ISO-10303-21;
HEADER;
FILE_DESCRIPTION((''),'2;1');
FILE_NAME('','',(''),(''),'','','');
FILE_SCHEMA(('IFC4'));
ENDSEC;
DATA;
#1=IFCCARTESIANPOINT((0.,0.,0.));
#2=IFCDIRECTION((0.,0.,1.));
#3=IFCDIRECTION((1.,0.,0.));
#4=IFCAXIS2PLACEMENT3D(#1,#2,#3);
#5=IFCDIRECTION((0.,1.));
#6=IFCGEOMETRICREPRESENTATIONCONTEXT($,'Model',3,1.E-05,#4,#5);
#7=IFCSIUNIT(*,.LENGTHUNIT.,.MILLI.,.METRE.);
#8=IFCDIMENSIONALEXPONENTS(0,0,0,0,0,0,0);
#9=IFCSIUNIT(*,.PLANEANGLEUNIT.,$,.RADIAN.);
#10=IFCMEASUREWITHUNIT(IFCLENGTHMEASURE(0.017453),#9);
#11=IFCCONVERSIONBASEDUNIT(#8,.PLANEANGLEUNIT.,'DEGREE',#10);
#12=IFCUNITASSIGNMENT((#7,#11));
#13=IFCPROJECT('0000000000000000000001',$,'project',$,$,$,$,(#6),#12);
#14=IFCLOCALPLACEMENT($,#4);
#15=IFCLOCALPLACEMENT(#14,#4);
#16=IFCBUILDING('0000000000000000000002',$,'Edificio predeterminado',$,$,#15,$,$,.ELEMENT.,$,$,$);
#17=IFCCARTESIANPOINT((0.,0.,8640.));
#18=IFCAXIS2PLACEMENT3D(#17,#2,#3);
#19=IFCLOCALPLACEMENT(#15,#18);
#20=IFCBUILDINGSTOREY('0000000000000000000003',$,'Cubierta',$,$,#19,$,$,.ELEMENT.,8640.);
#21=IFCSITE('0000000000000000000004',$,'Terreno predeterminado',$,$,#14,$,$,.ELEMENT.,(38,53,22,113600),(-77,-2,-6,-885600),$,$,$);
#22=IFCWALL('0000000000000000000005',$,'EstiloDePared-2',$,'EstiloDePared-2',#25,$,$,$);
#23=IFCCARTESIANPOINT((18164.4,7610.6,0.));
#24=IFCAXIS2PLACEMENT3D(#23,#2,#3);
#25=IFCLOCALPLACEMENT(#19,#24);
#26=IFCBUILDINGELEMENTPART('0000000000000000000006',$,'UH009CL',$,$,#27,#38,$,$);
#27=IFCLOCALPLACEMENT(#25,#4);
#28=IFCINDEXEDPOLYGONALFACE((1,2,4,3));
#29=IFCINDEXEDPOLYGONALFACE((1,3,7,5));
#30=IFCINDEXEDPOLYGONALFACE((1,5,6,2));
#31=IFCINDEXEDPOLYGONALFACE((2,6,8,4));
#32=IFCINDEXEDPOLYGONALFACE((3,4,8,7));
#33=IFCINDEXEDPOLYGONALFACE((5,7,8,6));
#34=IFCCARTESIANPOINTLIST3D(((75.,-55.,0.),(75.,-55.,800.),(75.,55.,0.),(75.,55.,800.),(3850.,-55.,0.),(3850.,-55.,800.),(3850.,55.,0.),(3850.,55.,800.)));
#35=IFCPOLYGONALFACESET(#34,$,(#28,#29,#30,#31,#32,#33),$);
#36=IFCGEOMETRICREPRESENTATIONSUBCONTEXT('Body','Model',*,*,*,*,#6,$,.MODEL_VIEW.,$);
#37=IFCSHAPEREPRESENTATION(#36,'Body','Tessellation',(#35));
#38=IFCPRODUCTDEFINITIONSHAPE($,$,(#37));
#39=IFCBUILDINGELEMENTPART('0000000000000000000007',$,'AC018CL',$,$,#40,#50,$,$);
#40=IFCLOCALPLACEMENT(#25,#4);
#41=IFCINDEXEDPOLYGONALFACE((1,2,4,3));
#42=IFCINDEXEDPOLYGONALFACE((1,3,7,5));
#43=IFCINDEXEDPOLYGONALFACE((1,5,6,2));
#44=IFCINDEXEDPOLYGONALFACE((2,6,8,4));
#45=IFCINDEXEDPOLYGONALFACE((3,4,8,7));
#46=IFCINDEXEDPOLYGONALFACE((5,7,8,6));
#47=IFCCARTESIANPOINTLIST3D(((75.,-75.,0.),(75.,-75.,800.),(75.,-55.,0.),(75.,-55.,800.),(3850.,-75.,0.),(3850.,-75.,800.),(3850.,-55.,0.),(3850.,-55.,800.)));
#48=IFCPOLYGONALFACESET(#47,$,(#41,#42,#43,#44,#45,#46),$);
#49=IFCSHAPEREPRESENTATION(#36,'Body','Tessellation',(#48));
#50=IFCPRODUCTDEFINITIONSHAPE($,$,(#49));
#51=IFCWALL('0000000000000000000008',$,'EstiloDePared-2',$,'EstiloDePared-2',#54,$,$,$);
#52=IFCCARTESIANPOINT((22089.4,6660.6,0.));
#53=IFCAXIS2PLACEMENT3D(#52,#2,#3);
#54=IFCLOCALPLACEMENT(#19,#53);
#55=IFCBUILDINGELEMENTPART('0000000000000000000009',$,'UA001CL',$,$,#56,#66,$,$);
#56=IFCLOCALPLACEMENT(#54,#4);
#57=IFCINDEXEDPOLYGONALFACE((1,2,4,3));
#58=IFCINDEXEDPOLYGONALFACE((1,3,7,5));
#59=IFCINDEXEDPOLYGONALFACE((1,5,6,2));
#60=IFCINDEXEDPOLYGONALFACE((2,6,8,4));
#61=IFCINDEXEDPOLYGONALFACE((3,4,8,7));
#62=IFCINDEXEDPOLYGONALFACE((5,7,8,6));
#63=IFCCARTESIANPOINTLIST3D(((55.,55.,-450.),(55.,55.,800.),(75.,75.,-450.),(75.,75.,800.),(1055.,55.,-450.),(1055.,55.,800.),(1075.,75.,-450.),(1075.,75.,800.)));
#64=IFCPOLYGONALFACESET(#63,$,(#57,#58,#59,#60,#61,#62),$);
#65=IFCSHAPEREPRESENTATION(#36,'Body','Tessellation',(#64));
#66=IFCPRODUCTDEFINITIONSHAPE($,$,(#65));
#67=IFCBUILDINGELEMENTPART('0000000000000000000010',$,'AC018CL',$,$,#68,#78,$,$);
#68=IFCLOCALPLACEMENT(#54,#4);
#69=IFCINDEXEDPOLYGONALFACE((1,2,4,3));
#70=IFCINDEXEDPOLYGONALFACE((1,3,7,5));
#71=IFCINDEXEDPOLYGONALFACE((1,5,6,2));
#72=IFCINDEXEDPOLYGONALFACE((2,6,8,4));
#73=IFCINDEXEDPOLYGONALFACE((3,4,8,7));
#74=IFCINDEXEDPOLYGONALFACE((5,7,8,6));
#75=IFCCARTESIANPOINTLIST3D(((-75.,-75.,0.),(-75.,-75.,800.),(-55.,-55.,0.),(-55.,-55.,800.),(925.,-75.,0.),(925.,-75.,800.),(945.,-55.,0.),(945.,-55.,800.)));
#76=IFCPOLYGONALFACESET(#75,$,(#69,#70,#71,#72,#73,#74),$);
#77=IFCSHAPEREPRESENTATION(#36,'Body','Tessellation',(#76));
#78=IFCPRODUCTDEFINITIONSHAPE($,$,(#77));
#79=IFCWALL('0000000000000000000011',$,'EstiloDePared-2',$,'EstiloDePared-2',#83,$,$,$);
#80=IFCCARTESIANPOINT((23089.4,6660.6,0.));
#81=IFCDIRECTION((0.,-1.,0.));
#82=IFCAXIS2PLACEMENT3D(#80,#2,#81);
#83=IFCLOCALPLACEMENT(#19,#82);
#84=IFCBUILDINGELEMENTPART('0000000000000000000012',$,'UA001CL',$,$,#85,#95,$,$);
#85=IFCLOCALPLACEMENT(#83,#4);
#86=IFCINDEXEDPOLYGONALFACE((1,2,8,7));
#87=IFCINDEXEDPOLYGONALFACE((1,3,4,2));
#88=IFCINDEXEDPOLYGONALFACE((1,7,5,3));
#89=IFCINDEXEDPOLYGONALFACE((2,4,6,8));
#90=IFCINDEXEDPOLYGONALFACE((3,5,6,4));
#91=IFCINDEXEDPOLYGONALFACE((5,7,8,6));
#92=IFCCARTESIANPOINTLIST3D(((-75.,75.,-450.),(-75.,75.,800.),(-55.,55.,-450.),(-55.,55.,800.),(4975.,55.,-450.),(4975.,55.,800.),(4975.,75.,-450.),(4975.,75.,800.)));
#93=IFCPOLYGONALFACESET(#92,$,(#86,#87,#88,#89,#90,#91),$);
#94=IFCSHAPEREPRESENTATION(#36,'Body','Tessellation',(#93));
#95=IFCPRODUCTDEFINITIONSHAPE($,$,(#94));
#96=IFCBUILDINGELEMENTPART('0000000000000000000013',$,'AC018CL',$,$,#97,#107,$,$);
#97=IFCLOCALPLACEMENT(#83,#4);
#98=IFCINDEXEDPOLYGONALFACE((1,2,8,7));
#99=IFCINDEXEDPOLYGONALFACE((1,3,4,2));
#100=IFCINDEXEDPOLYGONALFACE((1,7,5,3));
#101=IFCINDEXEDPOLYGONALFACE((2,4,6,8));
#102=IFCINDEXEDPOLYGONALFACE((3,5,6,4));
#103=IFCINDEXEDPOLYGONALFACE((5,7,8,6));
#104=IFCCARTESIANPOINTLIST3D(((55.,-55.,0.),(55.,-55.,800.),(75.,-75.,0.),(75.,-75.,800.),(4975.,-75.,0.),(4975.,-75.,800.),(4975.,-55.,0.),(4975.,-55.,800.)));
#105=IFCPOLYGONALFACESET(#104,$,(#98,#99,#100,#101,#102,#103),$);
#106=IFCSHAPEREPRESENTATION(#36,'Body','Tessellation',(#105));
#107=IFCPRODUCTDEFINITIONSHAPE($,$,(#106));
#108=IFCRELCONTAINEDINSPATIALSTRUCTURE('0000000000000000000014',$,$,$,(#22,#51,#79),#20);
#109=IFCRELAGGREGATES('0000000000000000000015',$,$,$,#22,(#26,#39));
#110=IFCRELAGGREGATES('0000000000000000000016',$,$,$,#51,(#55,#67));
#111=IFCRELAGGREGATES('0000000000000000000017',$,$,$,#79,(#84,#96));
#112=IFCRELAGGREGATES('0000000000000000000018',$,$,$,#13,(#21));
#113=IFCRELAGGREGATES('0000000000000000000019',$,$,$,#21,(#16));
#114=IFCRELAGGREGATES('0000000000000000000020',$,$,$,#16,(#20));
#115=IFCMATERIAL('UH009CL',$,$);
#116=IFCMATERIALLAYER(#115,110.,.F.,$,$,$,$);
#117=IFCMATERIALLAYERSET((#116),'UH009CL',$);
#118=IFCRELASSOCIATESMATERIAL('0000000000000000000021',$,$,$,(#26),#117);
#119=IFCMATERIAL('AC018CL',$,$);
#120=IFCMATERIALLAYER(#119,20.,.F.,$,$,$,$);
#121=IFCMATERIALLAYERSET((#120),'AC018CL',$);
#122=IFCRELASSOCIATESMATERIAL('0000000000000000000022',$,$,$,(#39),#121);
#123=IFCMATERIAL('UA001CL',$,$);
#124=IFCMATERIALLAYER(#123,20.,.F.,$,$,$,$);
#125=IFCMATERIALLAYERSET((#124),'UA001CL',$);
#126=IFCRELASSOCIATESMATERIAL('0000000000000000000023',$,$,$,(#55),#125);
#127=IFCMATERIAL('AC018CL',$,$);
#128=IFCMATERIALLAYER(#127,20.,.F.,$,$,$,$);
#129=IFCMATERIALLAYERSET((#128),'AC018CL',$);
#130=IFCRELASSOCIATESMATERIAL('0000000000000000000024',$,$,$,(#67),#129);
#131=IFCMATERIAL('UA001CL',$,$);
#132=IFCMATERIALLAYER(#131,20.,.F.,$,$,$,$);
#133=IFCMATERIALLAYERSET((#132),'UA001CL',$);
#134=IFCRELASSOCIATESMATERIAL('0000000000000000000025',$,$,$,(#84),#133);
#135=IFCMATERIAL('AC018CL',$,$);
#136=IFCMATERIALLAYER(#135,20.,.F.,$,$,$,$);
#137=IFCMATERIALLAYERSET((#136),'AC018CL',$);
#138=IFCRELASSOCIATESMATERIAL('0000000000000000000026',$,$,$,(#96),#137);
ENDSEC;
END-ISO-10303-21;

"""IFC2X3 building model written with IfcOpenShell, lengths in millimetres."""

from ifc_helpers import new_model, entity, si_unit, converted_unit, direction, frame, origin_with_axes, place, context, subcontext, project, spatial, polyline, outline, extrude, material, layer, layer_set, layer_usage, element, aggregate, save


model = new_model("IFC2X3")

# Units and contexts
model_context = context("Model", 3, precision=1e-05, world=origin_with_axes(), true_north=direction((0.0, 1.0)))
body_context = subcontext(model_context, "Body", "Model", "MODEL_VIEW")
ifc_project = project(units=[si_unit("LENGTHUNIT", "METRE", prefix="MILLI"), converted_unit("PLANEANGLEUNIT", "DEGREE", entity("IfcLengthMeasure", 0.017453), si_unit("PLANEANGLEUNIT", "RADIAN"), dimensions=[0, 0, 0, 0, 0, 0, 0])], contexts=[model_context])

# Site, building, storey
site_placement = place(None, origin_with_axes())
site = spatial("IfcSite", under=ifc_project, at=site_placement, Name="Terreno predeterminado", CompositionType="ELEMENT", RefLatitude=(38, 53, 22, 113600), RefLongitude=(-77, -2, -6, -885600))
building_placement = place(site_placement, origin_with_axes())
building = spatial("IfcBuilding", under=site, at=building_placement, Name="Edificio predeterminado", CompositionType="ELEMENT")
storey_placement = place(building_placement, frame((0.0, 0.0, 8640.0), z_axis=(0.0, 0.0, 1.0), x_axis=(1.0, 0.0, 0.0)))
storey = spatial("IfcBuildingStorey", under=building, at=storey_placement, Name="Cubierta", CompositionType="ELEMENT", Elevation=8640.0)

# Walls, building element parts
wall_1_placement = place(storey_placement, frame((18164.4, 7610.6, 0.0), z_axis=(0.0, 0.0, 1.0), x_axis=(1.0, 0.0, 0.0)))
wall_1 = element("IfcWall", 1, at=wall_1_placement, inside=storey, Name="EstiloDePared-2", ObjectType="EstiloDePared-2")
ifc_material_1 = material(Name="UH009CL")
ifc_layer_1 = layer(ifc_material_1, 110.0, ventilated=False)
ifc_layer_set_1 = layer_set([ifc_layer_1], Name="UH009CL")
ifc_layer_usage_1 = layer_usage(ifc_layer_set_1, "AXIS2", "NEGATIVE", -55.0)
building_element_part_1_placement = place(wall_1_placement, origin_with_axes())
building_element_part_1 = element("IfcBuildingElementPart", 2, at=building_element_part_1_placement, material=ifc_layer_usage_1, Name="UH009CL", context=body_context, shape_type="SweptSolid", body=[
    extrude(outline(polyline([(3850.0, 55.0), (3850.0, -55.0), (75.0, -55.0), (75.0, 55.0), (3850.0, 55.0)])), origin_with_axes(), (0.0, 0.0, 1.0), 800.0),
])
ifc_material_2 = material(Name="AC018CL")
ifc_layer_2 = layer(ifc_material_2, 20.0, ventilated=False)
ifc_layer_set_2 = layer_set([ifc_layer_2], Name="AC018CL")
ifc_layer_usage_2 = layer_usage(ifc_layer_set_2, "AXIS2", "NEGATIVE", 55.0)
building_element_part_2_placement = place(wall_1_placement, origin_with_axes())
building_element_part_2 = element("IfcBuildingElementPart", 3, at=building_element_part_2_placement, material=ifc_layer_usage_2, Name="AC018CL", context=body_context, shape_type="SweptSolid", body=[
    extrude(outline(polyline([(3850.0, -55.0), (3850.0, -75.0), (75.0, -75.0), (75.0, -55.0), (3850.0, -55.0)])), origin_with_axes(), (0.0, 0.0, 1.0), 800.0),
])
aggregate(wall_1, [building_element_part_1, building_element_part_2])
wall_2_placement = place(storey_placement, frame((22089.4, 6660.6, 0.0), z_axis=(0.0, 0.0, 1.0), x_axis=(1.0, 0.0, 0.0)))
wall_2 = element("IfcWall", 4, at=wall_2_placement, inside=storey, Name="EstiloDePared-2", ObjectType="EstiloDePared-2")
ifc_material_3 = material(Name="UA001CL")
ifc_layer_3 = layer(ifc_material_3, 20.0, ventilated=False)
ifc_layer_set_3 = layer_set([ifc_layer_3], Name="UA001CL")
ifc_layer_usage_3 = layer_usage(ifc_layer_set_3, "AXIS2", "NEGATIVE", -75.0)
building_element_part_3_placement = place(wall_2_placement, origin_with_axes())
building_element_part_3 = element("IfcBuildingElementPart", 5, at=building_element_part_3_placement, material=ifc_layer_usage_3, Name="UA001CL", context=body_context, shape_type="SweptSolid", body=[
    extrude(outline(polyline([(1075.0, 75.0), (1055.0, 55.0), (55.0, 55.0), (75.0, 75.0), (1075.0, 75.0)])), frame((0.0, 0.0, -450.0), z_axis=(0.0, 0.0, 1.0), x_axis=(1.0, 0.0, 0.0)), (0.0, 0.0, 1.0), 1250.0),
])
ifc_material_4 = material(Name="AC018CL")
ifc_layer_4 = layer(ifc_material_4, 20.0, ventilated=False)
ifc_layer_set_4 = layer_set([ifc_layer_4], Name="AC018CL")
ifc_layer_usage_4 = layer_usage(ifc_layer_set_4, "AXIS2", "NEGATIVE", 55.0)
building_element_part_4_placement = place(wall_2_placement, origin_with_axes())
building_element_part_4 = element("IfcBuildingElementPart", 6, at=building_element_part_4_placement, material=ifc_layer_usage_4, Name="AC018CL", context=body_context, shape_type="SweptSolid", body=[
    extrude(outline(polyline([(945.0, -55.0), (925.0, -75.0), (-75.0, -75.0), (-55.0, -55.0), (945.0, -55.0)])), origin_with_axes(), (0.0, 0.0, 1.0), 800.0),
])
aggregate(wall_2, [building_element_part_3, building_element_part_4])
wall_3_placement = place(storey_placement, frame((23089.4, 6660.6, 0.0), z_axis=(0.0, 0.0, 1.0), x_axis=(0.0, -1.0, 0.0)))
wall_3 = element("IfcWall", 7, at=wall_3_placement, inside=storey, Name="EstiloDePared-2", ObjectType="EstiloDePared-2")
ifc_material_5 = material(Name="UA001CL")
ifc_layer_5 = layer(ifc_material_5, 20.0, ventilated=False)
ifc_layer_set_5 = layer_set([ifc_layer_5], Name="UA001CL")
ifc_layer_usage_5 = layer_usage(ifc_layer_set_5, "AXIS2", "NEGATIVE", -75.0)
building_element_part_5_placement = place(wall_3_placement, origin_with_axes())
building_element_part_5 = element("IfcBuildingElementPart", 8, at=building_element_part_5_placement, material=ifc_layer_usage_5, Name="UA001CL", context=body_context, shape_type="SweptSolid", body=[
    extrude(outline(polyline([(4975.0, 75.0), (4975.0, 55.0), (-55.0, 55.0), (-75.0, 75.0), (4975.0, 75.0)])), frame((0.0, 0.0, -450.0), z_axis=(0.0, 0.0, 1.0), x_axis=(1.0, 0.0, 0.0)), (0.0, 0.0, 1.0), 1250.0),
])
ifc_material_6 = material(Name="AC018CL")
ifc_layer_6 = layer(ifc_material_6, 20.0, ventilated=False)
ifc_layer_set_6 = layer_set([ifc_layer_6], Name="AC018CL")
ifc_layer_usage_6 = layer_usage(ifc_layer_set_6, "AXIS2", "NEGATIVE", 55.0)
building_element_part_6_placement = place(wall_3_placement, origin_with_axes())
building_element_part_6 = element("IfcBuildingElementPart", 9, at=building_element_part_6_placement, material=ifc_layer_usage_6, Name="AC018CL", context=body_context, shape_type="SweptSolid", body=[
    extrude(outline(polyline([(4975.0, -55.0), (4975.0, -75.0), (75.0, -75.0), (55.0, -55.0), (4975.0, -55.0)])), origin_with_axes(), (0.0, 0.0, 1.0), 800.0),
])
aggregate(wall_3, [building_element_part_5, building_element_part_6])

save(model, "model.ifc")
